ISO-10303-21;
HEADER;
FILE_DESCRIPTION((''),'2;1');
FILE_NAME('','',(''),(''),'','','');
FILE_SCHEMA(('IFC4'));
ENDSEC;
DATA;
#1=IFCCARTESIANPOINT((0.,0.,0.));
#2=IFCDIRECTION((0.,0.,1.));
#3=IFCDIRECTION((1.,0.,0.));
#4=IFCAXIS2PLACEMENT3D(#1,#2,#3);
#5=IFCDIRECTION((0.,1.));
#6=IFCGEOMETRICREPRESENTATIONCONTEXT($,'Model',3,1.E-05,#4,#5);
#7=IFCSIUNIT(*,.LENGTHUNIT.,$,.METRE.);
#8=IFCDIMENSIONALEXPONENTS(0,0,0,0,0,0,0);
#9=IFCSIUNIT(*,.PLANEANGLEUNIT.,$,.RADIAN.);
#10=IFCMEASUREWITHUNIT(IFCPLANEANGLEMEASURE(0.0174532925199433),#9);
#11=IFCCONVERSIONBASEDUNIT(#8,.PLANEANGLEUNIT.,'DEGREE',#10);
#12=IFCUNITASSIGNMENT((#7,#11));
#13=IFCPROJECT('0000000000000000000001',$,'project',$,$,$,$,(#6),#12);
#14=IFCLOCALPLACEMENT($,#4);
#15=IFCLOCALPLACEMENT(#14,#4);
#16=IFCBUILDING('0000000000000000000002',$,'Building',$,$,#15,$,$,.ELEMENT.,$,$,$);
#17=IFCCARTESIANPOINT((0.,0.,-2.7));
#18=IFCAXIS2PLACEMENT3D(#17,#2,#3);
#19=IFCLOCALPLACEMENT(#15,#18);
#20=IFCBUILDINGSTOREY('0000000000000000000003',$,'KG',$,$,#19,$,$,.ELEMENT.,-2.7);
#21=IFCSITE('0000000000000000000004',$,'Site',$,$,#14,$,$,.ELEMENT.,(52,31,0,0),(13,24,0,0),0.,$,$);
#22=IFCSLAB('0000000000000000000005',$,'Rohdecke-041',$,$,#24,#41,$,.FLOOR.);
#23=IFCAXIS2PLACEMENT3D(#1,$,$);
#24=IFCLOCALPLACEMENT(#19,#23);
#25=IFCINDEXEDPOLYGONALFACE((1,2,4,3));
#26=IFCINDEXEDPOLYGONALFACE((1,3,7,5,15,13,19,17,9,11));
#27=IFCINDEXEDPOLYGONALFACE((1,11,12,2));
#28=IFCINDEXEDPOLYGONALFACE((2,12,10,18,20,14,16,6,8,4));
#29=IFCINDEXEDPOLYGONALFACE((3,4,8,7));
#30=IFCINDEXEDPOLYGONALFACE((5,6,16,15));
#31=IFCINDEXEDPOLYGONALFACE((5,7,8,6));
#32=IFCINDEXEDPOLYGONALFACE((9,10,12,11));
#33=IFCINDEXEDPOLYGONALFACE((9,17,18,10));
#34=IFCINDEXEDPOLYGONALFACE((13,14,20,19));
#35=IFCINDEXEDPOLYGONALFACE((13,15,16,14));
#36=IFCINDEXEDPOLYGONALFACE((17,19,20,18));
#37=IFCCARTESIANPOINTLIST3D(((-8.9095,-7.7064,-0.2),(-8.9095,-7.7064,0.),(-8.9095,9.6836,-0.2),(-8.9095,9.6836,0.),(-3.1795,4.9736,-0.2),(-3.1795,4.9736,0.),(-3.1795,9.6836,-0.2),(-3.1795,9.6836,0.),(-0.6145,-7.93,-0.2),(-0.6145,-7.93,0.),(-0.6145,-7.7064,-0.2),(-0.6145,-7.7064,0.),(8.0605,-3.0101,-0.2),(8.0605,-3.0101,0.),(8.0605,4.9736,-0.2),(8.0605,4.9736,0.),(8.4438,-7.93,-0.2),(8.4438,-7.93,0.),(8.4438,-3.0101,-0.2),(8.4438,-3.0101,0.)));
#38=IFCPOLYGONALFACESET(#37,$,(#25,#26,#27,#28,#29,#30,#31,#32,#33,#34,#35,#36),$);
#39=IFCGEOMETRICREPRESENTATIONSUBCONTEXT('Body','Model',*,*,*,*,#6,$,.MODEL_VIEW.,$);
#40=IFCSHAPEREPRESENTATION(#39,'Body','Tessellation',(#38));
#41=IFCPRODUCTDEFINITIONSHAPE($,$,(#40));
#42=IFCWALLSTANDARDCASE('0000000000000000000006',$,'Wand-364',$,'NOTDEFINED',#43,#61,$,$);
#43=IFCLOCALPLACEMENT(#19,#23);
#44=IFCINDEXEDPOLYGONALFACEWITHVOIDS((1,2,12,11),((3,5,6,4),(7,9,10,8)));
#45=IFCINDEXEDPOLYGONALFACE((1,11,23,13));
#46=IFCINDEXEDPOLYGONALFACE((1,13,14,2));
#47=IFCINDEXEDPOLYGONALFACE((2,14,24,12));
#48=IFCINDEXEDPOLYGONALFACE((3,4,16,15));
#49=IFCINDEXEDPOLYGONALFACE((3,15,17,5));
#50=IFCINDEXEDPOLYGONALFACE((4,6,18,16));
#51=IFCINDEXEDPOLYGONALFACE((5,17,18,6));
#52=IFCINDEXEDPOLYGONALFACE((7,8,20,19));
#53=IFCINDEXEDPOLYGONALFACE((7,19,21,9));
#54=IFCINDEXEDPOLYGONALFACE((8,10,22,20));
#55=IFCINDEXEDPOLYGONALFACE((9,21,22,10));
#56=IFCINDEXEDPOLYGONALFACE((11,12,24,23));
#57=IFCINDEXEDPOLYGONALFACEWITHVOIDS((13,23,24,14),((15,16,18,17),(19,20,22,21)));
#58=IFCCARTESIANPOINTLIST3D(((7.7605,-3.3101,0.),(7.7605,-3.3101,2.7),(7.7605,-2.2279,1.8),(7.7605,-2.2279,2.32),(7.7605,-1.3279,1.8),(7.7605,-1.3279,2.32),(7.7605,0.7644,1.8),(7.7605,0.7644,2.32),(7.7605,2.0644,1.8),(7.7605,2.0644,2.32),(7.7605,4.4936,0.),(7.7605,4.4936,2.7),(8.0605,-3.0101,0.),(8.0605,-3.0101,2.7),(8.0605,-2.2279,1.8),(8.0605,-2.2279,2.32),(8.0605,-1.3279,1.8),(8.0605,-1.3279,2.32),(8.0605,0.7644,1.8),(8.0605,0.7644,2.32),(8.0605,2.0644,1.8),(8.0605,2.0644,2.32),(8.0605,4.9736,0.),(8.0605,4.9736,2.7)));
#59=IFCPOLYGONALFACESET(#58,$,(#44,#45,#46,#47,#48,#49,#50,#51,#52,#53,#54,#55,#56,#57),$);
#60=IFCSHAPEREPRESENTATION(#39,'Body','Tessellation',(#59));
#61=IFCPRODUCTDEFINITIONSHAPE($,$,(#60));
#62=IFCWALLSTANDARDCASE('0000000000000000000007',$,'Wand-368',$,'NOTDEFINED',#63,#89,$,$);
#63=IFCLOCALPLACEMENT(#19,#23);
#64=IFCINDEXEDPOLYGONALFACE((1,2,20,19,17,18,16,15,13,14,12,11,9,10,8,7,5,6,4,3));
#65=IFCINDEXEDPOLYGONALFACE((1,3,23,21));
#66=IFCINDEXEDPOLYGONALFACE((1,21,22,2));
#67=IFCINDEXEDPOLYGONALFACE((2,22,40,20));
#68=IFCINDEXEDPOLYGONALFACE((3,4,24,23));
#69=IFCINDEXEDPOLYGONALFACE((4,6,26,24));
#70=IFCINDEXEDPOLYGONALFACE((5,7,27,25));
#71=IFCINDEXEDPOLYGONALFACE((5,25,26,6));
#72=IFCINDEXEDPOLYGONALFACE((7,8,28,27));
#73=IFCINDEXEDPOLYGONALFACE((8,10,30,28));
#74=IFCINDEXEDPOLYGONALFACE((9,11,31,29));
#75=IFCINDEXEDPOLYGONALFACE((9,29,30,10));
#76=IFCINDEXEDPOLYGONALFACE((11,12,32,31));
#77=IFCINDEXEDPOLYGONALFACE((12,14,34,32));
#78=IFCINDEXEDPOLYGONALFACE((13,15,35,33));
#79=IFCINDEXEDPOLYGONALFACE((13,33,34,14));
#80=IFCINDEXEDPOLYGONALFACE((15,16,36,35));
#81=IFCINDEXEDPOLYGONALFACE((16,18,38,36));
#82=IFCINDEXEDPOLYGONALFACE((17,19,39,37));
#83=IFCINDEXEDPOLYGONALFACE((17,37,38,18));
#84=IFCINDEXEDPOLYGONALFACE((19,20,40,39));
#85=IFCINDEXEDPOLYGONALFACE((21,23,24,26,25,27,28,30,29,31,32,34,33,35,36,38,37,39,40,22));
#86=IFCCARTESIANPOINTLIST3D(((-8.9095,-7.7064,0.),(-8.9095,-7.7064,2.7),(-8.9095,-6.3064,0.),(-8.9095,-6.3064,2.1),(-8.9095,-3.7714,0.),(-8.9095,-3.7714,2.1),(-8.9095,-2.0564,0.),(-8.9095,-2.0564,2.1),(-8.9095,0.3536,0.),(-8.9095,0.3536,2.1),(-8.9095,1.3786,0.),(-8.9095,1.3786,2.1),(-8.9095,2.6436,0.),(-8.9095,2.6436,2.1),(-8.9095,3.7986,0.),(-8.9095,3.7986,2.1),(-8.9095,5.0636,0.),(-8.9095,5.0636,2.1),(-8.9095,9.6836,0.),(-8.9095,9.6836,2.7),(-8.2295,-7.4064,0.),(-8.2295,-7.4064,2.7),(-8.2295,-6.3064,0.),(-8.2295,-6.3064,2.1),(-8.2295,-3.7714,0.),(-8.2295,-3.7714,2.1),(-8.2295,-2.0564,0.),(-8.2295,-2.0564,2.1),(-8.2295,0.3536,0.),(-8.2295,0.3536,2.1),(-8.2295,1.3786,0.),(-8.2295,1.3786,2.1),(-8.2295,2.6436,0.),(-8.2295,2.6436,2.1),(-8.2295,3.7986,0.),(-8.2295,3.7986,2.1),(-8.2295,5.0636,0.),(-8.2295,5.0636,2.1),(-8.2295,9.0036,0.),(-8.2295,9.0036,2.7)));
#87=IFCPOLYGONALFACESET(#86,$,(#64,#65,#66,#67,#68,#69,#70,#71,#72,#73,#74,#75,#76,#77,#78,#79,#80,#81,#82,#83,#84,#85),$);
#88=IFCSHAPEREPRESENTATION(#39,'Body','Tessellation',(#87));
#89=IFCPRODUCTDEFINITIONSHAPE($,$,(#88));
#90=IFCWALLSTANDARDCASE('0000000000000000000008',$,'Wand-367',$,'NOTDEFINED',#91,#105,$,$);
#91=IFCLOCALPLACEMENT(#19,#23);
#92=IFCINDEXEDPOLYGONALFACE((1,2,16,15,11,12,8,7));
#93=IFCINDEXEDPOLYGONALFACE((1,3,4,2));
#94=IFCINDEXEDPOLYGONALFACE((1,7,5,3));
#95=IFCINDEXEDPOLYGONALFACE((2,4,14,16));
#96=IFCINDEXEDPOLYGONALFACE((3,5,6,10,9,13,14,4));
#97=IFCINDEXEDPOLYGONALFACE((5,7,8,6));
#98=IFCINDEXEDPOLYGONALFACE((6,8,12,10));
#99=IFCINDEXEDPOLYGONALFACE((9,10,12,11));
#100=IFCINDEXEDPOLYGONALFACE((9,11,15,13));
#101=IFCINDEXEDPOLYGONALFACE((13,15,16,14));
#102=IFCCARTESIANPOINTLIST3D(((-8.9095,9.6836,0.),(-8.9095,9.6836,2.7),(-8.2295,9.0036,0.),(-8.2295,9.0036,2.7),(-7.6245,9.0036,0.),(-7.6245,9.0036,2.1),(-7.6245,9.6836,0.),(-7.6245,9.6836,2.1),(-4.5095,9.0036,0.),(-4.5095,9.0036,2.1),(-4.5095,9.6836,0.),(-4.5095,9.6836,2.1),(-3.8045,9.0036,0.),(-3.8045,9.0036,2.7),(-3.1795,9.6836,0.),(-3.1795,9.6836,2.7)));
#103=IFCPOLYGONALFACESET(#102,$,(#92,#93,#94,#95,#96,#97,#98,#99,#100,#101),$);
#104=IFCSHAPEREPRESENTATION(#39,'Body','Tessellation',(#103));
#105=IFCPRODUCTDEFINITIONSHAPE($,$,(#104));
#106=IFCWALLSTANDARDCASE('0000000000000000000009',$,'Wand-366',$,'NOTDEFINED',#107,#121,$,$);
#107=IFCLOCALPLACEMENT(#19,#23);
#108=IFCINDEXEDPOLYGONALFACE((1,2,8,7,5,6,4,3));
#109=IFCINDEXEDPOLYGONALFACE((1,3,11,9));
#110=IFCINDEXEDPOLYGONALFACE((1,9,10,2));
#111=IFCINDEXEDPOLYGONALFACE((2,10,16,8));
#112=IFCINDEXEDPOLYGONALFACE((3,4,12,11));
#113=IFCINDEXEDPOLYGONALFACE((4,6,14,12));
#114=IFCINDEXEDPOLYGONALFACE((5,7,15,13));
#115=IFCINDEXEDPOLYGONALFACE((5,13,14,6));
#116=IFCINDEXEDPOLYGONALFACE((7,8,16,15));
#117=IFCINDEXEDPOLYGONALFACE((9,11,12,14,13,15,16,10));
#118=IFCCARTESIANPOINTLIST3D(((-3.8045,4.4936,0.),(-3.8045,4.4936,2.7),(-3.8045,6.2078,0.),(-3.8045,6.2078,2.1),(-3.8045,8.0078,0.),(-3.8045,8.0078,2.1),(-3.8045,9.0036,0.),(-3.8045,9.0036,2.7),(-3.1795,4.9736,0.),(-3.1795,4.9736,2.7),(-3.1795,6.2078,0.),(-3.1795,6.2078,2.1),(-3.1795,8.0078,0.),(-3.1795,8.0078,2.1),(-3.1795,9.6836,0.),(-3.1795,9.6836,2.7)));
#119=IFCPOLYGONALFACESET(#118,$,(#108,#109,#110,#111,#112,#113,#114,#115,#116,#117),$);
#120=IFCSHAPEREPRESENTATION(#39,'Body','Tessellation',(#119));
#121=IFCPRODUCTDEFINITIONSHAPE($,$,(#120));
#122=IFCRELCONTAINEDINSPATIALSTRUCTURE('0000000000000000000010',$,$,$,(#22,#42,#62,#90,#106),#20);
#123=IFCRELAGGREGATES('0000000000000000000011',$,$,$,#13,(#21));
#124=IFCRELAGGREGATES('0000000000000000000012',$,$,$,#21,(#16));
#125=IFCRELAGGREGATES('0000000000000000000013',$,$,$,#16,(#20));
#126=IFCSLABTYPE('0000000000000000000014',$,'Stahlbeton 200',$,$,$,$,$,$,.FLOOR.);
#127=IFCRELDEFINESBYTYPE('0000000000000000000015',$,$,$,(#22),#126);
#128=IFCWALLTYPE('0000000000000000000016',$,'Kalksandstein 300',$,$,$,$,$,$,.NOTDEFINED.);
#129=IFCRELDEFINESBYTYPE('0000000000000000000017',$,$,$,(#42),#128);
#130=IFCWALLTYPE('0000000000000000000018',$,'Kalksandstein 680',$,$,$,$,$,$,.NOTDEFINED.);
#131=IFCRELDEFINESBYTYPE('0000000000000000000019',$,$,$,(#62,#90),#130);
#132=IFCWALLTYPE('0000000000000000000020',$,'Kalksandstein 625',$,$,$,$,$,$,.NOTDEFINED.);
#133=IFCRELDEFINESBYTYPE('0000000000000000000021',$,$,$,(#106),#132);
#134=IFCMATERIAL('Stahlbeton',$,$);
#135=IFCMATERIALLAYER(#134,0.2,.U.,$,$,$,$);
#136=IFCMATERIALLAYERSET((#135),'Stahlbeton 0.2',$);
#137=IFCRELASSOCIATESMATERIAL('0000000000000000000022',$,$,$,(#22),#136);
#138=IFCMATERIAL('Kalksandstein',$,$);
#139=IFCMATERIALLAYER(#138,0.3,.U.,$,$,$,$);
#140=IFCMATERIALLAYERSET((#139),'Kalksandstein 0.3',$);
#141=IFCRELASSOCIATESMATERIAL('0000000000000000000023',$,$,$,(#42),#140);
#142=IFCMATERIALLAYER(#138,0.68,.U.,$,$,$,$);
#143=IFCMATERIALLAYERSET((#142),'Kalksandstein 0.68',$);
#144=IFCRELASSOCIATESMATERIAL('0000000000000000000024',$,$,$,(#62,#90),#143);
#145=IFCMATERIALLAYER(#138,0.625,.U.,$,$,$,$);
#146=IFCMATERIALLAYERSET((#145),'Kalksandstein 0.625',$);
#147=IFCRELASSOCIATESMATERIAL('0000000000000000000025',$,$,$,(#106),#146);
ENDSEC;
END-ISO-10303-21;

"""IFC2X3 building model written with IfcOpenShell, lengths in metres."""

from ifc_helpers import new_model, entity, si_unit, converted_unit, direction, frame, origin_with_axes, origin_2d_with_axis, place, context, subcontext, project, spatial, polyline, rectangle, outline, extrude, material, layer, layer_set, layer_usage, type_object, element, save


model = new_model("IFC2X3")

# Units and contexts
model_context = context("Model", 3, precision=1e-05, world=origin_with_axes(), true_north=direction((0.0, 1.0)))
body_context = subcontext(model_context, "Body", "Model", "MODEL_VIEW")
ifc_project = project(units=[si_unit("LENGTHUNIT", "METRE"), converted_unit("PLANEANGLEUNIT", "DEGREE", entity("IfcPlaneAngleMeasure", 0.0174532925199433), si_unit("PLANEANGLEUNIT", "RADIAN"), dimensions=[0, 0, 0, 0, 0, 0, 0])], contexts=[model_context])

# Site, building, storey
site_placement = place(None, origin_with_axes())
site = spatial("IfcSite", under=ifc_project, at=site_placement, Name="Site", CompositionType="ELEMENT", RefLatitude=(52, 31, 0, 0), RefLongitude=(13, 24, 0, 0), RefElevation=0.0)
building_placement = place(site_placement, origin_with_axes())
building = spatial("IfcBuilding", under=site, at=building_placement, Name="Building", CompositionType="ELEMENT")
storey_placement = place(building_placement, frame((0.0, 0.0, -2.7), z_axis=(0.0, 0.0, 1.0), x_axis=(1.0, 0.0, 0.0)))
storey = spatial("IfcBuildingStorey", under=building, at=storey_placement, Name="KG", CompositionType="ELEMENT", Elevation=-2.7)

# Slab
ifc_material_1 = material(Name="Stahlbeton")
ifc_layer_1 = layer(ifc_material_1, 0.2, ventilated="UNKNOWN")
ifc_layer_set_1 = layer_set([ifc_layer_1], Name="Stahlbeton 0.2")
ifc_layer_usage_1 = layer_usage(ifc_layer_set_1, "AXIS3", "NEGATIVE", 0.2)
slab_type = type_object("IfcSlabType", Name="Stahlbeton 200", PredefinedType="FLOOR")
slab_placement = place(storey_placement, frame((-8.9095, 9.6836, 0.0), z_axis=(0.0, 0.0, 1.0), x_axis=(1.0, 0.0, 0.0)))
element("IfcSlab", 1, at=slab_placement, inside=storey, type_object=slab_type, material=ifc_layer_usage_1, Name="Rohdecke-041", PredefinedType="FLOOR", context=body_context, shape_type="SweptSolid", body=[
    extrude(outline(polyline([(0.0, 0.0), (0.0, -17.39), (8.295, -17.39), (8.295, -17.6137), (17.3533, -17.6137), (17.3533, -12.6938), (16.97, -12.6938), (16.97, -4.71), (5.73, -4.71), (5.73, 0.0), (0.0, 0.0)])), frame((0.0, 0.0, -0.2), z_axis=(0.0, 0.0, 1.0), x_axis=(1.0, 0.0, 0.0)), (0.0, 0.0, 1.0), 0.2),
])

# Walls, openings
ifc_material_2 = material(Name="Kalksandstein")
ifc_layer_2 = layer(ifc_material_2, 0.3, ventilated="UNKNOWN")
ifc_layer_set_2 = layer_set([ifc_layer_2], Name="Kalksandstein 0.3")
ifc_layer_usage_2 = layer_usage(ifc_layer_set_2, "AXIS2", "POSITIVE", 0.0)
wall_type_1 = type_object("IfcWallType", Name="Kalksandstein 300", PredefinedType="NOTDEFINED")
wall_1_placement = place(storey_placement, frame((8.0605, -3.0101, 0.0), z_axis=(0.0, 0.0, 1.0), x_axis=(0.0, 1.0, 0.0)))
wall_1 = element("IfcWallStandardCase", 2, at=wall_1_placement, inside=storey, type_object=wall_type_1, material=ifc_layer_usage_2, Name="Wand-364", ObjectType="NOTDEFINED", context=body_context, shape_type="SweptSolid", body=[
    extrude(outline(polyline([(0.0, 0.0), (7.9838, 0.0), (7.5038, 0.3), (-0.3, 0.3), (0.0, 0.0)])), origin_with_axes(), (0.0, 0.0, 1.0), 2.7),
])
opening_1_placement = place(wall_1_placement, frame((1.2323, 0.0, 1.8), z_axis=(0.0, 0.0, 1.0), x_axis=(1.0, 0.0, 0.0)))
element("IfcOpeningElement", 3, at=opening_1_placement, cuts=wall_1, context=body_context, shape_type="SweptSolid", body=[
    extrude(rectangle(XDim=0.9, YDim=0.52, at=origin_2d_with_axis()), frame((0.0, 0.3, 0.26), z_axis=(0.0, -1.0, 0.0), x_axis=(-1.0, 0.0, 0.0)), (0.0, 0.0, 1.0), 0.9),
])
opening_2_placement = place(wall_1_placement, frame((4.4245, 0.0, 1.8), z_axis=(0.0, 0.0, 1.0), x_axis=(1.0, 0.0, 0.0)))
element("IfcOpeningElement", 4, at=opening_2_placement, cuts=wall_1, context=body_context, shape_type="SweptSolid", body=[
    extrude(rectangle(XDim=1.3, YDim=0.52, at=origin_2d_with_axis()), frame((0.0, 0.3, 0.26), z_axis=(0.0, -1.0, 0.0), x_axis=(-1.0, 0.0, 0.0)), (0.0, 0.0, 1.0), 0.9),
])
ifc_layer_3 = layer(ifc_material_2, 0.68, ventilated="UNKNOWN")
ifc_layer_set_3 = layer_set([ifc_layer_3], Name="Kalksandstein 0.68")
ifc_layer_usage_3 = layer_usage(ifc_layer_set_3, "AXIS2", "POSITIVE", 0.0)
wall_type_2 = type_object("IfcWallType", Name="Kalksandstein 680", PredefinedType="NOTDEFINED")
wall_2_placement = place(storey_placement, frame((-8.9095, 9.6836, 0.0), z_axis=(0.0, 0.0, 1.0), x_axis=(0.0, -1.0, 0.0)))
wall_2 = element("IfcWallStandardCase", 5, at=wall_2_placement, inside=storey, type_object=wall_type_2, material=ifc_layer_usage_3, Name="Wand-368", ObjectType="NOTDEFINED", context=body_context, shape_type="SweptSolid", body=[
    extrude(outline(polyline([(0.0, 0.0), (17.39, 0.0), (17.09, 0.68), (0.68, 0.68), (0.0, 0.0)])), origin_with_axes(), (0.0, 0.0, 1.0), 2.7),
])
opening_3_placement = place(wall_2_placement, frame((5.2525, 0.0, 0.0), z_axis=(0.0, 0.0, 1.0), x_axis=(1.0, 0.0, 0.0)))
element("IfcOpeningElement", 6, at=opening_3_placement, cuts=wall_2, context=body_context, shape_type="SweptSolid", body=[
    extrude(rectangle(XDim=1.265, YDim=2.1, at=origin_2d_with_axis()), frame((0.0, 0.68, 1.05), z_axis=(0.0, -1.0, 0.0), x_axis=(-1.0, 0.0, 0.0)), (0.0, 0.0, 1.0), 2.04),
])
opening_4_placement = place(wall_2_placement, frame((7.6725, 0.0, 0.0), z_axis=(0.0, 0.0, 1.0), x_axis=(1.0, 0.0, 0.0)))
element("IfcOpeningElement", 7, at=opening_4_placement, cuts=wall_2, context=body_context, shape_type="SweptSolid", body=[
    extrude(rectangle(XDim=1.265, YDim=2.1, at=origin_2d_with_axis()), frame((0.0, 0.68, 1.05), z_axis=(0.0, -1.0, 0.0), x_axis=(-1.0, 0.0, 0.0)), (0.0, 0.0, 1.0), 2.04),
])
opening_5_placement = place(wall_2_placement, frame((10.535, 0.0, 0.0), z_axis=(0.0, 0.0, 1.0), x_axis=(1.0, 0.0, 0.0)))
element("IfcOpeningElement", 8, at=opening_5_placement, cuts=wall_2, context=body_context, shape_type="SweptSolid", body=[
    extrude(rectangle(XDim=2.41, YDim=2.1, at=origin_2d_with_axis()), frame((0.0, 0.68, 1.05), z_axis=(0.0, -1.0, 0.0), x_axis=(-1.0, 0.0, 0.0)), (0.0, 0.0, 1.0), 2.04),
])
opening_6_placement = place(wall_2_placement, frame((14.7225, 0.0, 0.0), z_axis=(0.0, 0.0, 1.0), x_axis=(1.0, 0.0, 0.0)))
element("IfcOpeningElement", 9, at=opening_6_placement, cuts=wall_2, context=body_context, shape_type="SweptSolid", body=[
    extrude(rectangle(XDim=2.535, YDim=2.1, at=origin_2d_with_axis()), frame((0.0, 0.68, 1.05), z_axis=(0.0, -1.0, 0.0), x_axis=(-1.0, 0.0, 0.0)), (0.0, 0.0, 1.0), 2.04),
])

# Wall, opening
ifc_layer_usage_4 = layer_usage(ifc_layer_set_3, "AXIS2", "POSITIVE", 0.0)
wall_3_placement = place(storey_placement, frame((-3.1795, 9.6836, 0.0), z_axis=(0.0, 0.0, 1.0), x_axis=(-1.0, 0.0, 0.0)))
wall_3 = element("IfcWallStandardCase", 10, at=wall_3_placement, inside=storey, type_object=wall_type_2, material=ifc_layer_usage_4, Name="Wand-367", ObjectType="NOTDEFINED", context=body_context, shape_type="SweptSolid", body=[
    extrude(outline(polyline([(0.0, 0.0), (5.73, 0.0), (5.05, 0.68), (0.625, 0.68), (0.0, 0.0)])), origin_with_axes(), (0.0, 0.0, 1.0), 2.7),
])
opening_7_placement = place(wall_3_placement, frame((2.8875, 0.0, 0.0), z_axis=(0.0, 0.0, 1.0), x_axis=(1.0, 0.0, 0.0)))
element("IfcOpeningElement", 11, at=opening_7_placement, cuts=wall_3, context=body_context, shape_type="SweptSolid", body=[
    extrude(rectangle(XDim=3.115, YDim=2.1, at=origin_2d_with_axis()), frame((0.0, 0.68, 1.05), z_axis=(0.0, -1.0, 0.0), x_axis=(-1.0, 0.0, 0.0)), (0.0, 0.0, 1.0), 2.04),
])

# Wall, opening
ifc_layer_4 = layer(ifc_material_2, 0.625, ventilated="UNKNOWN")
ifc_layer_set_4 = layer_set([ifc_layer_4], Name="Kalksandstein 0.625")
ifc_layer_usage_5 = layer_usage(ifc_layer_set_4, "AXIS2", "POSITIVE", 0.0)
wall_type_3 = type_object("IfcWallType", Name="Kalksandstein 625", PredefinedType="NOTDEFINED")
wall_4_placement = place(storey_placement, frame((-3.1795, 4.9736, 0.0), z_axis=(0.0, 0.0, 1.0), x_axis=(0.0, 1.0, 0.0)))
wall_4 = element("IfcWallStandardCase", 12, at=wall_4_placement, inside=storey, type_object=wall_type_3, material=ifc_layer_usage_5, Name="Wand-366", ObjectType="NOTDEFINED", context=body_context, shape_type="SweptSolid", body=[
    extrude(outline(polyline([(0.0, 0.0), (4.71, 0.0), (4.03, 0.625), (-0.48, 0.625), (0.0, 0.0)])), origin_with_axes(), (0.0, 0.0, 1.0), 2.7),
])
opening_8_placement = place(wall_4_placement, frame((2.1341, 0.0, 0.0), z_axis=(0.0, 0.0, 1.0), x_axis=(1.0, 0.0, 0.0)))
element("IfcOpeningElement", 13, at=opening_8_placement, cuts=wall_4, context=body_context, shape_type="SweptSolid", body=[
    extrude(rectangle(XDim=1.8, YDim=2.1, at=origin_2d_with_axis()), frame((0.0, 0.625, 1.05), z_axis=(0.0, -1.0, 0.0), x_axis=(-1.0, 0.0, 0.0)), (0.0, 0.0, 1.0), 1.875),
])

save(model, "model.ifc")
